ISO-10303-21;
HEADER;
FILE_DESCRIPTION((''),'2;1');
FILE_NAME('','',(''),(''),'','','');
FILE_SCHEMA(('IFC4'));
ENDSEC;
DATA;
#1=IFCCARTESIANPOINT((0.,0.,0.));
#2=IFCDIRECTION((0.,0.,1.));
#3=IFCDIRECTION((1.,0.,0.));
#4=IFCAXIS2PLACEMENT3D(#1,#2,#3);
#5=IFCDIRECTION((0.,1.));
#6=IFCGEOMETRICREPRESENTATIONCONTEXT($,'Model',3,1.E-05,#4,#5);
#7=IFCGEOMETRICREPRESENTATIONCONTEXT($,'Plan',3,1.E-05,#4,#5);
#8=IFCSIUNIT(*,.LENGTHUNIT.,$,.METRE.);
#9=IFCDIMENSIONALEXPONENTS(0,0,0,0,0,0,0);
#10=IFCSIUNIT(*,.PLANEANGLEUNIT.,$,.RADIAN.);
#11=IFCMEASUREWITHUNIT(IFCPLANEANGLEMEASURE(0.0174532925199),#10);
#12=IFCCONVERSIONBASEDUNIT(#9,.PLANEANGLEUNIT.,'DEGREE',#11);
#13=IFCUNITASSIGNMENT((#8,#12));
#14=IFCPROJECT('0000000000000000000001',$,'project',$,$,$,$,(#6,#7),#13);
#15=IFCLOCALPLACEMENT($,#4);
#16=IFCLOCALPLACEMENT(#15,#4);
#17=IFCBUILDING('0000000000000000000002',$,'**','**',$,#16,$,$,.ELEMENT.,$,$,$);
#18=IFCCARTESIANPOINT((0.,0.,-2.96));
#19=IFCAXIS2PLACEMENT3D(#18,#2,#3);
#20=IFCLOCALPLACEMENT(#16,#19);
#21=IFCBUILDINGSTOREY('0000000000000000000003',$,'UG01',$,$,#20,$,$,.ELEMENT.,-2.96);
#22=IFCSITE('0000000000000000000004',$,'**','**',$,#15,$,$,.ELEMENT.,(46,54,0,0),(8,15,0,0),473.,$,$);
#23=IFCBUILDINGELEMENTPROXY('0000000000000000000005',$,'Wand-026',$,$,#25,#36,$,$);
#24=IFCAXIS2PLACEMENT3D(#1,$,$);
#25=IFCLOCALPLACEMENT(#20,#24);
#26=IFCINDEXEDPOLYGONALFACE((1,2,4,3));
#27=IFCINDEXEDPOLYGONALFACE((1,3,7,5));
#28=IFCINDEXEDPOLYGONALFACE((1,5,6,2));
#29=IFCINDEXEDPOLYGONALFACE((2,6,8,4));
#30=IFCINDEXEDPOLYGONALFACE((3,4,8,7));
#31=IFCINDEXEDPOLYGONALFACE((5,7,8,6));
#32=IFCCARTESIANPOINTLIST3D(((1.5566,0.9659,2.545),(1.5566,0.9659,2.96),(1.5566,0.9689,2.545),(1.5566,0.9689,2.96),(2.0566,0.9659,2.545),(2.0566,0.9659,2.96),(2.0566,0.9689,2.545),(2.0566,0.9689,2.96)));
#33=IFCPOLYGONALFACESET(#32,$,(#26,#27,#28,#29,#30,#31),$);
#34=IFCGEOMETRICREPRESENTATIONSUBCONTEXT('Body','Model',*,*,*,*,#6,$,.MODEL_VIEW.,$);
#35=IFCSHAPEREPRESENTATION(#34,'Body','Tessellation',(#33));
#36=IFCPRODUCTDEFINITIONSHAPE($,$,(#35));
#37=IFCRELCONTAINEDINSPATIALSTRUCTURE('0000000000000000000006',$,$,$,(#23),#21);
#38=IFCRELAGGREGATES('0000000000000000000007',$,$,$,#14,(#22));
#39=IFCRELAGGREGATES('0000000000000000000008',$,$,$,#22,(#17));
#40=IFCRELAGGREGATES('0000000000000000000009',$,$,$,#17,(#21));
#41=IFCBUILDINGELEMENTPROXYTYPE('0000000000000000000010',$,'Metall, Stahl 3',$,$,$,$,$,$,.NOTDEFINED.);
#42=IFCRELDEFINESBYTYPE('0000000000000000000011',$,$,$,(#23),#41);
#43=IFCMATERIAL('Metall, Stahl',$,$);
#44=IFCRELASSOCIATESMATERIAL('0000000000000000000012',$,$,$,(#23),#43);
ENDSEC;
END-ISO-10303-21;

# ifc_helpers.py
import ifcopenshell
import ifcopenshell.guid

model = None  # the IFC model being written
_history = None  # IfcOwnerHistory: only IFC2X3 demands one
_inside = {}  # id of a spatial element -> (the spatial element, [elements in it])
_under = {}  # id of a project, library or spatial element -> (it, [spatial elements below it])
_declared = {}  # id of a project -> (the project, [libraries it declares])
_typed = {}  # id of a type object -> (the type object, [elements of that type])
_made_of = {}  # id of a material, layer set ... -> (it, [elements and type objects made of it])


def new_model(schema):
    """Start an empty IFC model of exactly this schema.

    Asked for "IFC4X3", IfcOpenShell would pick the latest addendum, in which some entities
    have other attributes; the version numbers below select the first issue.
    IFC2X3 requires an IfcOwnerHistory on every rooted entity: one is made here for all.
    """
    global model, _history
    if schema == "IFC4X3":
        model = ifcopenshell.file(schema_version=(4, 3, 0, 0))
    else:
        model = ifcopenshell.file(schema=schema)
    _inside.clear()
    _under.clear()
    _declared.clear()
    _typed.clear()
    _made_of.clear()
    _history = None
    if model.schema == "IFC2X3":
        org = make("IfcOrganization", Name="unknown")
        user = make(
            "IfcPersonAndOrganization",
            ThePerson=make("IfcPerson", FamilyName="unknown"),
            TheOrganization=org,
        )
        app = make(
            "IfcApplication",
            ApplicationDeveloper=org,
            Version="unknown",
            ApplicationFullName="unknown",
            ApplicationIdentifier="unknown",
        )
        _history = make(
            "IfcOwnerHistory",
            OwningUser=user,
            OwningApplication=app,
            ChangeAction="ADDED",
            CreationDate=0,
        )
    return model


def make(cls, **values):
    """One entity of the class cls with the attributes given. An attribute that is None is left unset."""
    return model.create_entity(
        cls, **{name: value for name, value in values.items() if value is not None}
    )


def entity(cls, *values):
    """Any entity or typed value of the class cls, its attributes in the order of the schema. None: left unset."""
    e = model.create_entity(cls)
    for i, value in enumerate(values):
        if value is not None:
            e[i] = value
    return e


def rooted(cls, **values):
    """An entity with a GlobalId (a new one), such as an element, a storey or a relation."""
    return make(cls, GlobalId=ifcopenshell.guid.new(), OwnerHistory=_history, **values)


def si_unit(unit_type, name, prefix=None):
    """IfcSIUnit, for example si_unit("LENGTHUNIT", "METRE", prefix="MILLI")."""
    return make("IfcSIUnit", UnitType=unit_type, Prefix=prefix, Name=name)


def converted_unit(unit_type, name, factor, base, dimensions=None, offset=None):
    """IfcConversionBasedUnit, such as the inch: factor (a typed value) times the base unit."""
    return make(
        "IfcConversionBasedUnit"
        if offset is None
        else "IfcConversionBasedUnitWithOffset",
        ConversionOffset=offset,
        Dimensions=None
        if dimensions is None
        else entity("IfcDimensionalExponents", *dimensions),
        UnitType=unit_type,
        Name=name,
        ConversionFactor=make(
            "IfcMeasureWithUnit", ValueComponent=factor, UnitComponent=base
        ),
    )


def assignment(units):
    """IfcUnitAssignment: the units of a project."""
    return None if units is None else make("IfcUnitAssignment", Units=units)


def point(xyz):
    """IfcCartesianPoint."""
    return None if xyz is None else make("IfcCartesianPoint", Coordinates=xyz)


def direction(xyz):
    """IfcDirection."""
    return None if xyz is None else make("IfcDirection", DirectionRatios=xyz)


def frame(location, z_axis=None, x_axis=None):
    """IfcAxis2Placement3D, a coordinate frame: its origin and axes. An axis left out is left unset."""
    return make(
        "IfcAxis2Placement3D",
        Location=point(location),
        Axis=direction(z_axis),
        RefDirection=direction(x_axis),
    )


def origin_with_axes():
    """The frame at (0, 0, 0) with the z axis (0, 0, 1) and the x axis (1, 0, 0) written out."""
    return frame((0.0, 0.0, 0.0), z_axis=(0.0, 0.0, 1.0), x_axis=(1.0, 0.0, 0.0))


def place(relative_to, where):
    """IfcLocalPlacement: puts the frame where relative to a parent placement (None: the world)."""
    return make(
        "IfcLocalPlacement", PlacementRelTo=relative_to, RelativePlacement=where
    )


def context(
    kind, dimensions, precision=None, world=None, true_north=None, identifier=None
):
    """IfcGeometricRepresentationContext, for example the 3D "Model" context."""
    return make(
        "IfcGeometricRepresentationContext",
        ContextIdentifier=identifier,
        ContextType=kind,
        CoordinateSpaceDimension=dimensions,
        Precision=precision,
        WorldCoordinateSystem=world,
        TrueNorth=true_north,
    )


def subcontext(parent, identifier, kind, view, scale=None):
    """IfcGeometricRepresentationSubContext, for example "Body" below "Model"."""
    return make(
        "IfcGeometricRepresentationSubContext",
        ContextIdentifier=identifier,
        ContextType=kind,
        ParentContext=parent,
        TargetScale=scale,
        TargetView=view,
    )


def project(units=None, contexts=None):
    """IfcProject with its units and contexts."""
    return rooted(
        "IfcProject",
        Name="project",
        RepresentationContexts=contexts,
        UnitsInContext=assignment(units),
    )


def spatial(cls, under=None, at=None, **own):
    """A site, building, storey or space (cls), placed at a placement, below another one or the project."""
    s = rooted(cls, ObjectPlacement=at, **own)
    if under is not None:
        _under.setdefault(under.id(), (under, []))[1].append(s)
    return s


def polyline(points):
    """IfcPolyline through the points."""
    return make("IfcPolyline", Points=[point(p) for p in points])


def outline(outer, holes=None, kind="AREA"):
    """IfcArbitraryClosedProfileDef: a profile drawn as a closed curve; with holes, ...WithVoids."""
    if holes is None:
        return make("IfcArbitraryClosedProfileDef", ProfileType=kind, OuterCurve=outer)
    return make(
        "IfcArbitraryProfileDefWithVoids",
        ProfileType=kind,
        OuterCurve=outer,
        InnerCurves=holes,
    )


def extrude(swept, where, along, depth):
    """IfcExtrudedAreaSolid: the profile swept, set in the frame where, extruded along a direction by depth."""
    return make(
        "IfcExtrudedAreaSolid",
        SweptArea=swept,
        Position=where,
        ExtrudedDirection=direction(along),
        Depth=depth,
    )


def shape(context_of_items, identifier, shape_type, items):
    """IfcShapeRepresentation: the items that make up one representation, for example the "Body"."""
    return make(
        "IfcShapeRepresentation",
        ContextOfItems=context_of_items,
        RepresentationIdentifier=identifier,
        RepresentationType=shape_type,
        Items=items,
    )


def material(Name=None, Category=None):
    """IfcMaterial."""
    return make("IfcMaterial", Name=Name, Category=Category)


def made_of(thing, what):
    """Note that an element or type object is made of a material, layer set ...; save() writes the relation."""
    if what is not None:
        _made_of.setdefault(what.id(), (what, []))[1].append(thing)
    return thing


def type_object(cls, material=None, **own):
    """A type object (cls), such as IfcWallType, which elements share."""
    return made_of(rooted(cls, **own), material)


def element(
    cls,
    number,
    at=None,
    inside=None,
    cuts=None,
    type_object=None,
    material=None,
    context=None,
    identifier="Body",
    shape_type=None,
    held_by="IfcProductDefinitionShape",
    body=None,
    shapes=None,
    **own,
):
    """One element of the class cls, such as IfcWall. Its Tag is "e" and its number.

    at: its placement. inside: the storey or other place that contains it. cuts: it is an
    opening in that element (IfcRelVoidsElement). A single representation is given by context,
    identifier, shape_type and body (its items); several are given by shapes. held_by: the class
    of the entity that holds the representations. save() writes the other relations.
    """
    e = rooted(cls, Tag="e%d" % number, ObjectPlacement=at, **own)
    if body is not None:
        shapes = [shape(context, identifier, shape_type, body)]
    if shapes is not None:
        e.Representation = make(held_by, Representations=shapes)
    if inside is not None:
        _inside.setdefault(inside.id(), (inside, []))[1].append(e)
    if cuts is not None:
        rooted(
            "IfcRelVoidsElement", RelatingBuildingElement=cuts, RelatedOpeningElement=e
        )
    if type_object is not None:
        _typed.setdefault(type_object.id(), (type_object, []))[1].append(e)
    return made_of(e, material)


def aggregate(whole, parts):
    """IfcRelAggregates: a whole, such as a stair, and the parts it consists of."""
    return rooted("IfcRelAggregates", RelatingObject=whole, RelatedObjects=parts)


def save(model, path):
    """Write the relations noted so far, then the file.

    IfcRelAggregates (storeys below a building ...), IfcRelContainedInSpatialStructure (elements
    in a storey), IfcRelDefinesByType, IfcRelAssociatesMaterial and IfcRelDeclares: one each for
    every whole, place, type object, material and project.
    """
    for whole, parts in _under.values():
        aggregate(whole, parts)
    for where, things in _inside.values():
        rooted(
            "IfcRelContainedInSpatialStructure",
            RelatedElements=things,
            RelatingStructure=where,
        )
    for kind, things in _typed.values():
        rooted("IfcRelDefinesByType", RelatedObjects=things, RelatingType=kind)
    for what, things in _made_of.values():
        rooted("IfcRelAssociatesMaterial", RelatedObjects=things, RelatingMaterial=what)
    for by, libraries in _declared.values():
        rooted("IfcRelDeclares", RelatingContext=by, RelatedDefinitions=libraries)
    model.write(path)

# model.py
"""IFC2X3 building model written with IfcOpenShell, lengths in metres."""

from ifc_helpers import new_model, entity, si_unit, converted_unit, direction, frame, origin_with_axes, place, context, subcontext, project, spatial, polyline, outline, extrude, material, type_object, element, save


model = new_model("IFC2X3")

# Units and contexts
model_context = context("Model", 3, precision=1e-05, world=origin_with_axes(), true_north=direction((0.0, 1.0)))
plan_context = context("Plan", 3, precision=1e-05, world=origin_with_axes(), true_north=direction((0.0, 1.0)))
body_context = subcontext(model_context, "Body", "Model", "MODEL_VIEW")
ifc_project = project(units=[si_unit("LENGTHUNIT", "METRE"), converted_unit("PLANEANGLEUNIT", "DEGREE", entity("IfcPlaneAngleMeasure", 0.0174532925199), si_unit("PLANEANGLEUNIT", "RADIAN"), dimensions=[0, 0, 0, 0, 0, 0, 0])], contexts=[model_context, plan_context])

# Site, building, storey
site_placement = place(None, origin_with_axes())
site = spatial("IfcSite", under=ifc_project, at=site_placement, Name="**", Description="**", CompositionType="ELEMENT", RefLatitude=(46, 54, 0, 0), RefLongitude=(8, 15, 0, 0), RefElevation=473.0)
building_placement = place(site_placement, origin_with_axes())
building = spatial("IfcBuilding", under=site, at=building_placement, Name="**", Description="**", CompositionType="ELEMENT")
storey_placement = place(building_placement, frame((0.0, 0.0, -2.96), z_axis=(0.0, 0.0, 1.0), x_axis=(1.0, 0.0, 0.0)))
storey = spatial("IfcBuildingStorey", under=building, at=storey_placement, Name="UG01", CompositionType="ELEMENT", Elevation=-2.96)

# Building element proxy
ifc_material = material(Name="Metall, Stahl")
building_element_proxy_type = type_object("IfcBuildingElementProxyType", Name="Metall, Stahl 3", PredefinedType="NOTDEFINED")
proxy_placement = place(storey_placement, frame((1.5566, 0.9659, 2.545), z_axis=(0.0, 0.0, 1.0), x_axis=(1.0, 0.0, 0.0)))
element("IfcBuildingElementProxy", 1, at=proxy_placement, inside=storey, type_object=building_element_proxy_type, material=ifc_material, Name="Wand-026", context=body_context, shape_type="SweptSolid", body=[
    extrude(outline(polyline([(0.0, 0.0), (0.5, 0.0), (0.5, 0.003), (0.0, 0.003), (0.0, 0.0)])), origin_with_axes(), (0.0, 0.0, 1.0), 0.415),
])

save(model, "model.ifc")
